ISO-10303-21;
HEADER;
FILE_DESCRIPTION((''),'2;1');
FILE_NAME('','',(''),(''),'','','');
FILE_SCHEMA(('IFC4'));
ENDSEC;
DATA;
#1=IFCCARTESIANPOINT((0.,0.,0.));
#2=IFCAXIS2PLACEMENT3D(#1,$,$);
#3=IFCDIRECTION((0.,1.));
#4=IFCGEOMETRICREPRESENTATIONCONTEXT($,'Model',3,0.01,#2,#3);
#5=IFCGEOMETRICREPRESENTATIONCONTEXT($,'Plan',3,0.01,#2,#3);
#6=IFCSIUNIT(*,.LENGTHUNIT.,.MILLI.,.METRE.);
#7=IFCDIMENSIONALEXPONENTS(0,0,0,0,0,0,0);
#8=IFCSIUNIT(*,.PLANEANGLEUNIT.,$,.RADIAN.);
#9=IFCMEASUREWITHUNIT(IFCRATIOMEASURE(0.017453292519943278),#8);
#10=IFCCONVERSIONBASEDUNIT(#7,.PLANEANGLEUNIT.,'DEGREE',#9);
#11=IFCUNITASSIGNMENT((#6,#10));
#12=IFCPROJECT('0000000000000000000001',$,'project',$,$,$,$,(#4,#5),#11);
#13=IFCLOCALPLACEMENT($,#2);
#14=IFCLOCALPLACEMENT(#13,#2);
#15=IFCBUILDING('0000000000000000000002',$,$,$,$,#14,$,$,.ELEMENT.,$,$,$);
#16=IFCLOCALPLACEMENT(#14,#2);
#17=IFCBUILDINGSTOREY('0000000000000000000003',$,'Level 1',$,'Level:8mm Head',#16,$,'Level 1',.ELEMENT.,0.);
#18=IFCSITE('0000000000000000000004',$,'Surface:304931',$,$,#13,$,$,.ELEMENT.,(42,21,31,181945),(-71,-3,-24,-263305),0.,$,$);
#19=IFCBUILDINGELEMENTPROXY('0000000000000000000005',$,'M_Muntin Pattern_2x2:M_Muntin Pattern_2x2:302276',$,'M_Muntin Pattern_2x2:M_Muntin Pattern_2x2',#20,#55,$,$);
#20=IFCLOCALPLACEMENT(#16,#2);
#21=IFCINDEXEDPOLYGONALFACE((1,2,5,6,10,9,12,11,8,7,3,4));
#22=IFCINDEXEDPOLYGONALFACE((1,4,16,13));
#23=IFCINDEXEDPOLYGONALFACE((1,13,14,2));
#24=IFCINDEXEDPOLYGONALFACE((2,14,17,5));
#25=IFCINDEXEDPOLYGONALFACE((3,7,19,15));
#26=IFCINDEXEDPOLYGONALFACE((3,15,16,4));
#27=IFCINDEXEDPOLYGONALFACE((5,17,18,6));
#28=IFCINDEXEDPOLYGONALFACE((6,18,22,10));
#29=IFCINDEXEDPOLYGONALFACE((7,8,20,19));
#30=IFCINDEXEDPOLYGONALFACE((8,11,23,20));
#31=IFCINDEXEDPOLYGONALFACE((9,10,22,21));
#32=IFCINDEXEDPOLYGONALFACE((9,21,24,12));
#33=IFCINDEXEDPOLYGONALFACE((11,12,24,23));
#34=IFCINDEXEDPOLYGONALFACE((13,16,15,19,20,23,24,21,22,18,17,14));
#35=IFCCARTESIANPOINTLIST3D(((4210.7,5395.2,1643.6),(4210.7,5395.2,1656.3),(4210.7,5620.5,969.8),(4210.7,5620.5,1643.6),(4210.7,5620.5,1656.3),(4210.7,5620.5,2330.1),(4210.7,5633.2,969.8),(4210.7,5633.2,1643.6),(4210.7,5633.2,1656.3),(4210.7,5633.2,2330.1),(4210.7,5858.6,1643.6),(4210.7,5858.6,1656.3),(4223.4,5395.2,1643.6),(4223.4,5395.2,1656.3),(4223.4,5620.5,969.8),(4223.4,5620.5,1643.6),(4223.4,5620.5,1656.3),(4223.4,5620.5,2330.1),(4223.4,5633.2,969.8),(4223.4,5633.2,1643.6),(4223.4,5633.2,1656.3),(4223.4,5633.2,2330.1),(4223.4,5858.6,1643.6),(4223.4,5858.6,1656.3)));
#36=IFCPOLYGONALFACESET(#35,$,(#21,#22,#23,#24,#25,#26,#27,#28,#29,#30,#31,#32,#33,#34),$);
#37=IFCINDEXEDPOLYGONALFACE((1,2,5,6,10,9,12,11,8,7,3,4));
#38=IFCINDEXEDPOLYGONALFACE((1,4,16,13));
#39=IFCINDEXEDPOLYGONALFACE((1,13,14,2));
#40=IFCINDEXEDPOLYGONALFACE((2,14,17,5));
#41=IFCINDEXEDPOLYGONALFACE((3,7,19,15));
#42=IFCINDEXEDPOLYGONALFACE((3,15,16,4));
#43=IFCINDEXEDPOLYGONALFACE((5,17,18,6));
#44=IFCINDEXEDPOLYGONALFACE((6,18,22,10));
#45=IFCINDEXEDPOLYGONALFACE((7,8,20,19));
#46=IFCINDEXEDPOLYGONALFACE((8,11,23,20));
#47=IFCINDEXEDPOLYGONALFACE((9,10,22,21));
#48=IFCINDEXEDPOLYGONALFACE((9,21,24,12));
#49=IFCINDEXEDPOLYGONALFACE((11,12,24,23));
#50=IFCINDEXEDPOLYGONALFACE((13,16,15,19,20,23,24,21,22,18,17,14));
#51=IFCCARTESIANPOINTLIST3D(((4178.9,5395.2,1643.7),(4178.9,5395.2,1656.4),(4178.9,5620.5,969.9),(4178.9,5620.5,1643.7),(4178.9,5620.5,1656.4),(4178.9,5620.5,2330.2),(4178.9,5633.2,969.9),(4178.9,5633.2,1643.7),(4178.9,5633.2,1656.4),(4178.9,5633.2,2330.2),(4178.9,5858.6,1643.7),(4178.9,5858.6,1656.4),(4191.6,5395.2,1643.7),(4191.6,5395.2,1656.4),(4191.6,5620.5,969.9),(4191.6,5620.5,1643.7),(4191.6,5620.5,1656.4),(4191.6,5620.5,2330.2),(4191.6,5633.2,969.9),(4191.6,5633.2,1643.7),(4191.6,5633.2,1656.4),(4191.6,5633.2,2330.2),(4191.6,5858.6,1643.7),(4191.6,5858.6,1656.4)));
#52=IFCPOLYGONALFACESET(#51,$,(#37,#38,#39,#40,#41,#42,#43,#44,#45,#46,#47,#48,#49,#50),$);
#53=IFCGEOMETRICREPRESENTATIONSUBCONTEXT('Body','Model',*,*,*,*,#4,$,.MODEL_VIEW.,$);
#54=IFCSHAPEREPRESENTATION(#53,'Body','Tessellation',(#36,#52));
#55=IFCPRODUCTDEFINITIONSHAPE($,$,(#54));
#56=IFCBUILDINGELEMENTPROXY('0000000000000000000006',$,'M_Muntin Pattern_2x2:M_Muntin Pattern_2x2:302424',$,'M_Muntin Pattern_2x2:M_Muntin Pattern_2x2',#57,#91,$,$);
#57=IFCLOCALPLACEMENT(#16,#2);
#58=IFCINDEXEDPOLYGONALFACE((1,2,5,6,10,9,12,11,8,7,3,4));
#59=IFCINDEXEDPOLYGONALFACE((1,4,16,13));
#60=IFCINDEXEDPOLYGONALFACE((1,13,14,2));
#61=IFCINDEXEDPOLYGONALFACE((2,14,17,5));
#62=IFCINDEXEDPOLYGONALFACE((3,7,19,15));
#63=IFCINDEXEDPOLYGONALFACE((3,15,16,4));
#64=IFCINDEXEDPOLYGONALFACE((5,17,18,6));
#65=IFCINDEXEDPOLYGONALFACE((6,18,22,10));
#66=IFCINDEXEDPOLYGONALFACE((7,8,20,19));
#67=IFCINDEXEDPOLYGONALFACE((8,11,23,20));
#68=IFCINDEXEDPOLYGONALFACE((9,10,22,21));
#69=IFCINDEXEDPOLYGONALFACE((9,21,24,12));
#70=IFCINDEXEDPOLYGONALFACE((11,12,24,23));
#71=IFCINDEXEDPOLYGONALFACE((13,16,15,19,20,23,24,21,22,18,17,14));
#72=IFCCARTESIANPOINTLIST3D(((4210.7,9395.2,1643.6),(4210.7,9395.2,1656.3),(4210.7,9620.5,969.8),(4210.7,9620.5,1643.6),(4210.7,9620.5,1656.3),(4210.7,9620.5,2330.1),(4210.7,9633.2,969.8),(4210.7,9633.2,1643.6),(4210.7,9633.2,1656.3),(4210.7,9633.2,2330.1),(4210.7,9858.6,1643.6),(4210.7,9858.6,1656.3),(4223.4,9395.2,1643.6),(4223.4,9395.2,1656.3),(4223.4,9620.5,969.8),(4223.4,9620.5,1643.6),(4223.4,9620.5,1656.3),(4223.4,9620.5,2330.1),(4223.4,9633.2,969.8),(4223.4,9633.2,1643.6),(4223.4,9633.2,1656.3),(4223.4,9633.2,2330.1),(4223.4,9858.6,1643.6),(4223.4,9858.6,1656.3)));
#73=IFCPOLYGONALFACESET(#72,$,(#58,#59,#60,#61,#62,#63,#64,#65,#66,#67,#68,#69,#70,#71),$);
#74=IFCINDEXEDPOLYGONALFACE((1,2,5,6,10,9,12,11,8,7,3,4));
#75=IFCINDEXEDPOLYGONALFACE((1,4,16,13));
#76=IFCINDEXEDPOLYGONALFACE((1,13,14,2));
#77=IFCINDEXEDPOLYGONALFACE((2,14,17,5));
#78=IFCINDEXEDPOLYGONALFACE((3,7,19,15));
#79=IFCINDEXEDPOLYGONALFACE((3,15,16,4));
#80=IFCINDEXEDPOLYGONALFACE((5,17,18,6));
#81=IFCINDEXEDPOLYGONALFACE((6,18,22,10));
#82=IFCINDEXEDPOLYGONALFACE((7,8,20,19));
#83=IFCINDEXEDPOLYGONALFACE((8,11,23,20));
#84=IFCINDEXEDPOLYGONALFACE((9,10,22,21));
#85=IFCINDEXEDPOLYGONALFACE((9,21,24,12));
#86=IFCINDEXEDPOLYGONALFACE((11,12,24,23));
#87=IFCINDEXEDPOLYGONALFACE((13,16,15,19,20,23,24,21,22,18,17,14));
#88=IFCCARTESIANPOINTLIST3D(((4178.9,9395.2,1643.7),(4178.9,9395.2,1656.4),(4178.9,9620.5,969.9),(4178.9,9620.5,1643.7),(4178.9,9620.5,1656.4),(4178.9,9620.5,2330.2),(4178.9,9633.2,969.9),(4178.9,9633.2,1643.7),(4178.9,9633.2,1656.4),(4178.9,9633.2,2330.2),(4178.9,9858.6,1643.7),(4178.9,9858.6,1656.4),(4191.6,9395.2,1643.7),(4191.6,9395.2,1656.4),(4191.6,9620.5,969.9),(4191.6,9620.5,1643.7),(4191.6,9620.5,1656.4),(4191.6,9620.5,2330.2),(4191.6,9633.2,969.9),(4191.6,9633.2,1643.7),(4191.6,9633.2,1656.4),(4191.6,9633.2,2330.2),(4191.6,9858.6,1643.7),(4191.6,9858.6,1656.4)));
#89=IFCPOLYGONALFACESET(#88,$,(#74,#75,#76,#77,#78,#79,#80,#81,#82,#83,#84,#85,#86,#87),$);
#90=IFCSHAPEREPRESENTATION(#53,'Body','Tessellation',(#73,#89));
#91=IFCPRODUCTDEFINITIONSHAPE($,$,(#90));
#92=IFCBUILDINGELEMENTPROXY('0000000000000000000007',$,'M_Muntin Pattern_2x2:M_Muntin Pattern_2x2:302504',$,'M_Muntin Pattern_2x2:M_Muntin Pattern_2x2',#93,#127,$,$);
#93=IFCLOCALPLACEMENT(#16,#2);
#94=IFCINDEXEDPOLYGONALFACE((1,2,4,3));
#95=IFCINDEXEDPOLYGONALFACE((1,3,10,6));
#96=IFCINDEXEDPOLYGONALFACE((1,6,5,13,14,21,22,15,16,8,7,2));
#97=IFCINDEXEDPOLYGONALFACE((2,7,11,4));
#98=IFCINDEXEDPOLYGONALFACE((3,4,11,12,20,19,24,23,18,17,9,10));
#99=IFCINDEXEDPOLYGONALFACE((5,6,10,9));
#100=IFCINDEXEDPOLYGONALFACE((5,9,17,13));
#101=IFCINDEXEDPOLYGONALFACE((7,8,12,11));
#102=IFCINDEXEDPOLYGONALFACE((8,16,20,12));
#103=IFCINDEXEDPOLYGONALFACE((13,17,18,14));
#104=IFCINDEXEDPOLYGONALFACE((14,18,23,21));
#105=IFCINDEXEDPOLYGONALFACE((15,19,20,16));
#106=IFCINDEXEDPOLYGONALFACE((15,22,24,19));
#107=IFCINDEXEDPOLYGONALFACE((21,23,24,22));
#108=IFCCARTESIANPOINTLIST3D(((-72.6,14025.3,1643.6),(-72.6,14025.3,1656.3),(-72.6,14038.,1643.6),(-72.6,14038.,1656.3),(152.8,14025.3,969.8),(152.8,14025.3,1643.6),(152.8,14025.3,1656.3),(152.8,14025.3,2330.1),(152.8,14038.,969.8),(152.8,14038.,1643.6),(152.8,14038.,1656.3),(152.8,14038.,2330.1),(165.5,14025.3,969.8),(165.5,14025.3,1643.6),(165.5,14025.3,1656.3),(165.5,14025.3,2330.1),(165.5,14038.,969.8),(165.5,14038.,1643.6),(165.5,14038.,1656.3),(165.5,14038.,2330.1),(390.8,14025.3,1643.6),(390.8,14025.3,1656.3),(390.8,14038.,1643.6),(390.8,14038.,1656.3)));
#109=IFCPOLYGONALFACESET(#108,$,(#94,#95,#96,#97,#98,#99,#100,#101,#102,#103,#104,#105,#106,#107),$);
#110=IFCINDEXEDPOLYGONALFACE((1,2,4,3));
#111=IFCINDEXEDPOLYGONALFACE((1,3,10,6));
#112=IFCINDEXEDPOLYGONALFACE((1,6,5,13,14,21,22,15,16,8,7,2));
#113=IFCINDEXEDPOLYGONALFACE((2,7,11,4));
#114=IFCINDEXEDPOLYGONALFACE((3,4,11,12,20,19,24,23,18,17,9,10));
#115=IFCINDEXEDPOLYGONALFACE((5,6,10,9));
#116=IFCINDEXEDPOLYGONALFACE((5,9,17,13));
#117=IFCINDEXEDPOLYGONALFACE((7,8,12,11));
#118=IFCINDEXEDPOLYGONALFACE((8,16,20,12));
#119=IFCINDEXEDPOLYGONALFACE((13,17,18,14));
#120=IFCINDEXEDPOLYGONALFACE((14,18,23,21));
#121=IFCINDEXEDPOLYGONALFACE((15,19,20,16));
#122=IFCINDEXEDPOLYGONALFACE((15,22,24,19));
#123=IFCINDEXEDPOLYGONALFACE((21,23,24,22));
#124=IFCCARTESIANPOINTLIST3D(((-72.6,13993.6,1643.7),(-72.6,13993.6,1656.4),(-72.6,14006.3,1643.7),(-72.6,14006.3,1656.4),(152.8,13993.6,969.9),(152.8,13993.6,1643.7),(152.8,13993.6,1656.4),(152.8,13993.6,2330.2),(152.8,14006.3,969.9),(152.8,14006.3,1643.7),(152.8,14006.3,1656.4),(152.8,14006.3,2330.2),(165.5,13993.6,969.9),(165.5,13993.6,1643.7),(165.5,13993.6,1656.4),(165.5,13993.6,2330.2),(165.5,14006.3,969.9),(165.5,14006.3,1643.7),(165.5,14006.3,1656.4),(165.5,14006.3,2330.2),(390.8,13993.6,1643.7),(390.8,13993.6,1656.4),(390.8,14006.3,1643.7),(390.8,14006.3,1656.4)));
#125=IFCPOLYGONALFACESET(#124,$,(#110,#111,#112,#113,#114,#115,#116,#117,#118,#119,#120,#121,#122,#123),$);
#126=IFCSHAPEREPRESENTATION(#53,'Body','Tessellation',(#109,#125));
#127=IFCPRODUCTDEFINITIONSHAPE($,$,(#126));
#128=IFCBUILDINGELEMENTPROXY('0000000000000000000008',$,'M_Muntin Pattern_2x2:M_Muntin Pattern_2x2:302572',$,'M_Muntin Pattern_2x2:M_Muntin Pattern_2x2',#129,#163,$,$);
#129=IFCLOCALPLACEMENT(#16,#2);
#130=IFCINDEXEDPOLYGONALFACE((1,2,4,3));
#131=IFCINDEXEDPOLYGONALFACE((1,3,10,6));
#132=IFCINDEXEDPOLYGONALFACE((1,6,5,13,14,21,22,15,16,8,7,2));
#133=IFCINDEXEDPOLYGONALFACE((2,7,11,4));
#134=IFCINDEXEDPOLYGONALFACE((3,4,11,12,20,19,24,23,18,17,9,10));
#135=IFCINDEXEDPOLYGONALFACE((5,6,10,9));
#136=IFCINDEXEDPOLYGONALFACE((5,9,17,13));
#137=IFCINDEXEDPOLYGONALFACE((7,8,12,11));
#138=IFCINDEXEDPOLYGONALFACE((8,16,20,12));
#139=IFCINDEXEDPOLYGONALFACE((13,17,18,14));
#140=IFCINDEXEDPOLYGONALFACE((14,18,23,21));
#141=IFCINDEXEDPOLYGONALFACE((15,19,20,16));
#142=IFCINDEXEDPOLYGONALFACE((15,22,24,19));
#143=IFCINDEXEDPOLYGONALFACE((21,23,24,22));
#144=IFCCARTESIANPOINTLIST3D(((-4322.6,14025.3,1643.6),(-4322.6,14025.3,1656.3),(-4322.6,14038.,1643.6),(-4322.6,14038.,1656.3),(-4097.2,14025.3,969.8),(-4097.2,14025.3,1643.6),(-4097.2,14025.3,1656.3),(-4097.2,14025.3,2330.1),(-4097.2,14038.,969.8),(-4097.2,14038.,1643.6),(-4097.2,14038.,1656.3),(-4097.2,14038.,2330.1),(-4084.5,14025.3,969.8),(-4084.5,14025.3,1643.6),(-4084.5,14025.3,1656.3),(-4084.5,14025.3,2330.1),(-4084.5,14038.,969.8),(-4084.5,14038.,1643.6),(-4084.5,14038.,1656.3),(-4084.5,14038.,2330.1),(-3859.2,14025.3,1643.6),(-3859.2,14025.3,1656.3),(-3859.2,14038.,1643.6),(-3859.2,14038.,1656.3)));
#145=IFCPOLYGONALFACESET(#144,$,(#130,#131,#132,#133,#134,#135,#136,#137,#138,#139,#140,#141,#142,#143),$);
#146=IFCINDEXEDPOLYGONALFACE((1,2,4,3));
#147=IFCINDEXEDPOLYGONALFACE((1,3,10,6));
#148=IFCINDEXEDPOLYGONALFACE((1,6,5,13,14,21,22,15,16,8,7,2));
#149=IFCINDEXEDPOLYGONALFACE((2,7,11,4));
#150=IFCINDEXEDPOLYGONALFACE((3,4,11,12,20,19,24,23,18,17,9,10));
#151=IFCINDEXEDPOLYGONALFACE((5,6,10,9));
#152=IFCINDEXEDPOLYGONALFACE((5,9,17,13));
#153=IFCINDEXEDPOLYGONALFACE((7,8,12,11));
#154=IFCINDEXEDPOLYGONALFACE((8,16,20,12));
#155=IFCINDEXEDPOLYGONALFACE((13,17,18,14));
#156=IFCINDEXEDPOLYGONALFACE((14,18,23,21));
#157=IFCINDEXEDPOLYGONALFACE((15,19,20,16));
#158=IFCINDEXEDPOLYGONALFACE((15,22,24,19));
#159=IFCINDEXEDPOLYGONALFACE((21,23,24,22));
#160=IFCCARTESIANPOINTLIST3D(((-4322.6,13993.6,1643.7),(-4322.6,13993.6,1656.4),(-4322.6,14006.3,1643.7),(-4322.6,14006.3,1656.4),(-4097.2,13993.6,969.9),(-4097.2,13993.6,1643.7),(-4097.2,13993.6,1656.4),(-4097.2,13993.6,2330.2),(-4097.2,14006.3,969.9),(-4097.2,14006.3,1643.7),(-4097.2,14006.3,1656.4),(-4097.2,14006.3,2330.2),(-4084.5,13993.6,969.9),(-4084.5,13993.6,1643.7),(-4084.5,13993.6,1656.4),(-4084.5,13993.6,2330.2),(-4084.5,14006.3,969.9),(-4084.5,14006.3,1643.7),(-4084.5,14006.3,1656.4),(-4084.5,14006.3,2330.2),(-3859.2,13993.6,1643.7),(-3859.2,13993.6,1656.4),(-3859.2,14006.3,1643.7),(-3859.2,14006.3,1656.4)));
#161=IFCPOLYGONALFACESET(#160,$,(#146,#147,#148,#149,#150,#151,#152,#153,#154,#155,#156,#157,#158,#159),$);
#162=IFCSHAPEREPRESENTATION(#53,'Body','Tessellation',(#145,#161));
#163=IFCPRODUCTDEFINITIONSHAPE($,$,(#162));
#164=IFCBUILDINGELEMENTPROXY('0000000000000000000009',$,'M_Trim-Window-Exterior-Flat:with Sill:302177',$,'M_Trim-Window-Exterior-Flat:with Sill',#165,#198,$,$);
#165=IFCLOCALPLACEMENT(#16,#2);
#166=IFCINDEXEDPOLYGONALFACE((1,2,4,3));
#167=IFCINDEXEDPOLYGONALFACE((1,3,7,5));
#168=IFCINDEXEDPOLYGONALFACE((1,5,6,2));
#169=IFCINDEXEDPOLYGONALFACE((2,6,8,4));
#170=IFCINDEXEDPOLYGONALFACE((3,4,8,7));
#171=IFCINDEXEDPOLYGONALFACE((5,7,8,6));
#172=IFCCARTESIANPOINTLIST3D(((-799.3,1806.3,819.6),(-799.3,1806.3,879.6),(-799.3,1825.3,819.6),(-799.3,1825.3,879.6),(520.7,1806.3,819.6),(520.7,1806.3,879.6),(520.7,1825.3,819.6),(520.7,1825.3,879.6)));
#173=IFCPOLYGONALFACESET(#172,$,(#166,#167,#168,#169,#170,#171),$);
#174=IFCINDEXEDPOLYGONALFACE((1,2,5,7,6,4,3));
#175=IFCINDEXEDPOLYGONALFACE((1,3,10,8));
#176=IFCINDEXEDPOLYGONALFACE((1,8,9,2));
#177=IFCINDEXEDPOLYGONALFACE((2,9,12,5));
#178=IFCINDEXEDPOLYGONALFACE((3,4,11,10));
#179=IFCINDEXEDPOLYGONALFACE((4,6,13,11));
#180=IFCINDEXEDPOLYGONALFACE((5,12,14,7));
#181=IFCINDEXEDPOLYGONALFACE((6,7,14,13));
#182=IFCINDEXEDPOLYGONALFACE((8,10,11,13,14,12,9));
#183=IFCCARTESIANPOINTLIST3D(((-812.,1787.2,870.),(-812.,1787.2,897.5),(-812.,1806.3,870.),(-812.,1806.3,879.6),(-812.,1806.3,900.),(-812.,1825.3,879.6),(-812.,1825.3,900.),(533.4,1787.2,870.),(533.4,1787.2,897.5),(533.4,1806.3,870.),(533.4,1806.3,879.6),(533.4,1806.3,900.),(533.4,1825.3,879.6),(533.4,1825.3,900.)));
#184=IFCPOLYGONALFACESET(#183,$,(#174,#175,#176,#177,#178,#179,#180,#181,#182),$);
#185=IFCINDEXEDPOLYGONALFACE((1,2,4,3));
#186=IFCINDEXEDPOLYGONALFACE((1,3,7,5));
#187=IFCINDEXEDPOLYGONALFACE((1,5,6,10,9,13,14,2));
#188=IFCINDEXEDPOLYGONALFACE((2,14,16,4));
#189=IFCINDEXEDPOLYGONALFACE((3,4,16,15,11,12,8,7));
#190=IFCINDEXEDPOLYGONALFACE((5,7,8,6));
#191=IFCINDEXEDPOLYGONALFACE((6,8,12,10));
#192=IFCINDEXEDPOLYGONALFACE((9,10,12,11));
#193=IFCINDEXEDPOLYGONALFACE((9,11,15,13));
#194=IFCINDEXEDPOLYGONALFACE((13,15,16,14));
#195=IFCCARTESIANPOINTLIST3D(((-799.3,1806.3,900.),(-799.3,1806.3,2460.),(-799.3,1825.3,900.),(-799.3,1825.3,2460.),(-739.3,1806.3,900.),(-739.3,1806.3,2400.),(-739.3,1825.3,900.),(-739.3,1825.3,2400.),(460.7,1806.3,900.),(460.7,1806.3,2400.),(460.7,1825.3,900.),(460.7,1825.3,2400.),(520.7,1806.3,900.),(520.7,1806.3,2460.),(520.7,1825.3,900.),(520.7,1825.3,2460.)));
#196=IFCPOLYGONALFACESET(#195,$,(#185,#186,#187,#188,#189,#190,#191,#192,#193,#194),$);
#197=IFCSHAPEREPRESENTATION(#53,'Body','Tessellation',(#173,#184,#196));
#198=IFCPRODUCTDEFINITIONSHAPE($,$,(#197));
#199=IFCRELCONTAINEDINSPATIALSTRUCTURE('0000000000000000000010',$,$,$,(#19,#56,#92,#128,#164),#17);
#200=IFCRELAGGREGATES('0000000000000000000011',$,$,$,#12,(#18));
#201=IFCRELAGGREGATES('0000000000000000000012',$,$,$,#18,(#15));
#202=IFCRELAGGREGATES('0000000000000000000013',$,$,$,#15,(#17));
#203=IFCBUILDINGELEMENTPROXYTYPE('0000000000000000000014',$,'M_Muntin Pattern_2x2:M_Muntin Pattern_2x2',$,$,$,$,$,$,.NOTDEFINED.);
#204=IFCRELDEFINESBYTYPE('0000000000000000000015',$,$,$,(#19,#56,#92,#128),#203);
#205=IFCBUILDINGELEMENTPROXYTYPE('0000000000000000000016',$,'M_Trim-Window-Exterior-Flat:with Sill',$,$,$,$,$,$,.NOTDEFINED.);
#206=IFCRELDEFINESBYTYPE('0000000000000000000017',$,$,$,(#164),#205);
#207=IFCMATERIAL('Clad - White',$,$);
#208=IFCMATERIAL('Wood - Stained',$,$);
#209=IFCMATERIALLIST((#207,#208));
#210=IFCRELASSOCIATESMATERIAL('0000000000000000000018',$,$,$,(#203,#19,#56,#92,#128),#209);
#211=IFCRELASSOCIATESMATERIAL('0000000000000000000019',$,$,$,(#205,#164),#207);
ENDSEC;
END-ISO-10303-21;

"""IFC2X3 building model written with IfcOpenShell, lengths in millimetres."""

from ifc_helpers import new_model, entity, si_unit, converted_unit, direction, frame, frame_2d, origin, place, context, subcontext, project, spatial, polyline, rectangle, outline, extrude, source, transform, mapped, material, material_list, type_object, type_shapes, element, save


model = new_model("IFC2X3")

# Units and contexts
model_context = context("Model", 3, precision=0.01, world=origin(), true_north=direction((0.0, 1.0)))
plan_context = context("Plan", 3, precision=0.01, world=origin(), true_north=direction((0.0, 1.0)))
body_context = subcontext(model_context, "Body", "Model", "MODEL_VIEW")
ifc_project = project(units=[si_unit("LENGTHUNIT", "METRE", prefix="MILLI"), converted_unit("PLANEANGLEUNIT", "DEGREE", entity("IfcRatioMeasure", 0.017453292519943278), si_unit("PLANEANGLEUNIT", "RADIAN"), dimensions=[0, 0, 0, 0, 0, 0, 0])], contexts=[model_context, plan_context])

# Site, building, storey
site_placement = place(None, origin())
site = spatial("IfcSite", under=ifc_project, at=site_placement, Name="Surface:304931", CompositionType="ELEMENT", RefLatitude=(42, 21, 31, 181945), RefLongitude=(-71, -3, -24, -263305), RefElevation=0.0)
building_placement = place(site_placement, origin())
building = spatial("IfcBuilding", under=site, at=building_placement, CompositionType="ELEMENT")
storey_placement = place(building_placement, origin())
storey = spatial("IfcBuildingStorey", under=building, at=storey_placement, Name="Level 1", ObjectType="Level:8mm Head", LongName="Level 1", CompositionType="ELEMENT", Elevation=0.0)

# Building element proxies
ifc_material_1 = material(Name="Clad - White")
ifc_material_2 = material(Name="Wood - Stained")
ifc_material_list_1 = material_list([ifc_material_1, ifc_material_2])
building_element_proxy_type_1 = type_object("IfcBuildingElementProxyType", Name="M_Muntin Pattern_2x2:M_Muntin Pattern_2x2", PredefinedType="NOTDEFINED", material=ifc_material_list_1)
shared_shape_1 = source(origin(), body_context, "Body", "SweptSolid", [
    extrude(outline(polyline([(6.4, -6.4), (680.1, -6.4), (680.1, 6.3), (6.4, 6.3), (6.4, 231.7), (-6.3, 231.7), (-6.3, 6.3), (-680.2, 6.3), (-680.2, -6.4), (-6.3, -6.4), (-6.3, -231.7), (6.4, -231.7), (6.4, -6.4)])), frame((0.0, -22.2, 680.1), z_axis=(0.0, 1.0, 0.0), x_axis=(0.0, 0.0, 1.0)), (0.0, 0.0, 1.0), 12.7),
    extrude(outline(polyline([(6.4, -6.4), (680.2, -6.4), (680.2, 6.3), (6.4, 6.3), (6.4, 231.7), (-6.3, 231.7), (-6.3, 6.3), (-680.2, 6.3), (-680.2, -6.4), (-6.3, -6.4), (-6.3, -231.7), (6.4, -231.7), (6.4, -6.4)])), frame((0.0, 9.5, 680.2), z_axis=(0.0, 1.0, 0.0), x_axis=(0.0, 0.0, 1.0)), (0.0, 0.0, 1.0), 12.7),
])
type_shapes(building_element_proxy_type_1, [shared_shape_1])
for number, where, z_axis, x_axis, name in (
    (1, (4201.2, 5626.9, 969.9), (0.0, 0.0, 1.0), (0.0, 1.0, 0.0), "M_Muntin Pattern_2x2:M_Muntin Pattern_2x2:302276"),
    (2, (4201.2, 9626.9, 969.9), (0.0, 0.0, 1.0), (0.0, 1.0, 0.0), "M_Muntin Pattern_2x2:M_Muntin Pattern_2x2:302424"),
    (3, (159.1, 14015.8, 969.9), (0.0, 0.0, 1.0), (-1.0, 0.0, 0.0), "M_Muntin Pattern_2x2:M_Muntin Pattern_2x2:302504"),
    (4, (-4090.9, 14015.8, 969.9), (0.0, 0.0, 1.0), (-1.0, 0.0, 0.0), "M_Muntin Pattern_2x2:M_Muntin Pattern_2x2:302572"),
):
    element("IfcBuildingElementProxy", number, at=place(storey_placement, frame(where, z_axis=z_axis, x_axis=x_axis)), inside=storey, type_object=building_element_proxy_type_1, material=ifc_material_list_1, Name=name, ObjectType="M_Muntin Pattern_2x2:M_Muntin Pattern_2x2", context=body_context, shape_type="MappedRepresentation", body=[
        mapped(shared_shape_1, transform((0.0, 0.0, 0.0), scale=1.0)),
    ])
building_element_proxy_type_2 = type_object("IfcBuildingElementProxyType", Name="M_Trim-Window-Exterior-Flat:with Sill", PredefinedType="NOTDEFINED", material=ifc_material_1)
shared_shape_2 = source(origin(), body_context, "Body", "SweptSolid", [
    extrude(rectangle(XDim=1320.0, YDim=60.0, at=frame_2d((0.0, 0.0), x_axis=(1.0, 0.0))), frame((0.0, -1550.4, 0.0), z_axis=(0.0, 0.0, 1.0), x_axis=(-1.0, 0.0, 0.0)), (0.0, 0.0, 1.0), 19.0),
    extrude(outline(polyline([(-19.0, -15.2), (0.0, -15.2), (0.0, -5.7), (19.0, -5.7), (19.0, 14.8), (0.0, 14.8), (-19.0, 12.3), (-19.0, -15.2)])), frame((-672.7, -1514.8, 19.0), z_axis=(1.0, 0.0, 0.0), x_axis=(0.0, 0.0, -1.0)), (0.0, 0.0, 1.0), 1345.4),
    extrude(outline(polyline([(-795.0, -660.0), (765.0, -660.0), (765.0, -600.0), (-735.0, -600.0), (-735.0, 600.0), (765.0, 600.0), (765.0, 660.0), (-795.0, 660.0), (-795.0, -660.0)])), frame((0.0, -735.0, 0.0), z_axis=(0.0, 0.0, 1.0), x_axis=(0.0, -1.0, 0.0)), (0.0, 0.0, 1.0), 19.0),
])
type_shapes(building_element_proxy_type_2, [shared_shape_2])
for number, where, z_axis, x_axis, name in (
    (5, (-139.3, 1825.3, 2400.0), (0.0, -1.0, 0.0), (1.0, 0.0, 0.0), "M_Trim-Window-Exterior-Flat:with Sill:302177"),
):
    element("IfcBuildingElementProxy", number, at=place(storey_placement, frame(where, z_axis=z_axis, x_axis=x_axis)), inside=storey, type_object=building_element_proxy_type_2, material=ifc_material_1, Name=name, ObjectType="M_Trim-Window-Exterior-Flat:with Sill", context=body_context, shape_type="MappedRepresentation", body=[
        mapped(shared_shape_2, transform((0.0, 0.0, 0.0), scale=1.0)),
    ])

save(model, "model.ifc")
